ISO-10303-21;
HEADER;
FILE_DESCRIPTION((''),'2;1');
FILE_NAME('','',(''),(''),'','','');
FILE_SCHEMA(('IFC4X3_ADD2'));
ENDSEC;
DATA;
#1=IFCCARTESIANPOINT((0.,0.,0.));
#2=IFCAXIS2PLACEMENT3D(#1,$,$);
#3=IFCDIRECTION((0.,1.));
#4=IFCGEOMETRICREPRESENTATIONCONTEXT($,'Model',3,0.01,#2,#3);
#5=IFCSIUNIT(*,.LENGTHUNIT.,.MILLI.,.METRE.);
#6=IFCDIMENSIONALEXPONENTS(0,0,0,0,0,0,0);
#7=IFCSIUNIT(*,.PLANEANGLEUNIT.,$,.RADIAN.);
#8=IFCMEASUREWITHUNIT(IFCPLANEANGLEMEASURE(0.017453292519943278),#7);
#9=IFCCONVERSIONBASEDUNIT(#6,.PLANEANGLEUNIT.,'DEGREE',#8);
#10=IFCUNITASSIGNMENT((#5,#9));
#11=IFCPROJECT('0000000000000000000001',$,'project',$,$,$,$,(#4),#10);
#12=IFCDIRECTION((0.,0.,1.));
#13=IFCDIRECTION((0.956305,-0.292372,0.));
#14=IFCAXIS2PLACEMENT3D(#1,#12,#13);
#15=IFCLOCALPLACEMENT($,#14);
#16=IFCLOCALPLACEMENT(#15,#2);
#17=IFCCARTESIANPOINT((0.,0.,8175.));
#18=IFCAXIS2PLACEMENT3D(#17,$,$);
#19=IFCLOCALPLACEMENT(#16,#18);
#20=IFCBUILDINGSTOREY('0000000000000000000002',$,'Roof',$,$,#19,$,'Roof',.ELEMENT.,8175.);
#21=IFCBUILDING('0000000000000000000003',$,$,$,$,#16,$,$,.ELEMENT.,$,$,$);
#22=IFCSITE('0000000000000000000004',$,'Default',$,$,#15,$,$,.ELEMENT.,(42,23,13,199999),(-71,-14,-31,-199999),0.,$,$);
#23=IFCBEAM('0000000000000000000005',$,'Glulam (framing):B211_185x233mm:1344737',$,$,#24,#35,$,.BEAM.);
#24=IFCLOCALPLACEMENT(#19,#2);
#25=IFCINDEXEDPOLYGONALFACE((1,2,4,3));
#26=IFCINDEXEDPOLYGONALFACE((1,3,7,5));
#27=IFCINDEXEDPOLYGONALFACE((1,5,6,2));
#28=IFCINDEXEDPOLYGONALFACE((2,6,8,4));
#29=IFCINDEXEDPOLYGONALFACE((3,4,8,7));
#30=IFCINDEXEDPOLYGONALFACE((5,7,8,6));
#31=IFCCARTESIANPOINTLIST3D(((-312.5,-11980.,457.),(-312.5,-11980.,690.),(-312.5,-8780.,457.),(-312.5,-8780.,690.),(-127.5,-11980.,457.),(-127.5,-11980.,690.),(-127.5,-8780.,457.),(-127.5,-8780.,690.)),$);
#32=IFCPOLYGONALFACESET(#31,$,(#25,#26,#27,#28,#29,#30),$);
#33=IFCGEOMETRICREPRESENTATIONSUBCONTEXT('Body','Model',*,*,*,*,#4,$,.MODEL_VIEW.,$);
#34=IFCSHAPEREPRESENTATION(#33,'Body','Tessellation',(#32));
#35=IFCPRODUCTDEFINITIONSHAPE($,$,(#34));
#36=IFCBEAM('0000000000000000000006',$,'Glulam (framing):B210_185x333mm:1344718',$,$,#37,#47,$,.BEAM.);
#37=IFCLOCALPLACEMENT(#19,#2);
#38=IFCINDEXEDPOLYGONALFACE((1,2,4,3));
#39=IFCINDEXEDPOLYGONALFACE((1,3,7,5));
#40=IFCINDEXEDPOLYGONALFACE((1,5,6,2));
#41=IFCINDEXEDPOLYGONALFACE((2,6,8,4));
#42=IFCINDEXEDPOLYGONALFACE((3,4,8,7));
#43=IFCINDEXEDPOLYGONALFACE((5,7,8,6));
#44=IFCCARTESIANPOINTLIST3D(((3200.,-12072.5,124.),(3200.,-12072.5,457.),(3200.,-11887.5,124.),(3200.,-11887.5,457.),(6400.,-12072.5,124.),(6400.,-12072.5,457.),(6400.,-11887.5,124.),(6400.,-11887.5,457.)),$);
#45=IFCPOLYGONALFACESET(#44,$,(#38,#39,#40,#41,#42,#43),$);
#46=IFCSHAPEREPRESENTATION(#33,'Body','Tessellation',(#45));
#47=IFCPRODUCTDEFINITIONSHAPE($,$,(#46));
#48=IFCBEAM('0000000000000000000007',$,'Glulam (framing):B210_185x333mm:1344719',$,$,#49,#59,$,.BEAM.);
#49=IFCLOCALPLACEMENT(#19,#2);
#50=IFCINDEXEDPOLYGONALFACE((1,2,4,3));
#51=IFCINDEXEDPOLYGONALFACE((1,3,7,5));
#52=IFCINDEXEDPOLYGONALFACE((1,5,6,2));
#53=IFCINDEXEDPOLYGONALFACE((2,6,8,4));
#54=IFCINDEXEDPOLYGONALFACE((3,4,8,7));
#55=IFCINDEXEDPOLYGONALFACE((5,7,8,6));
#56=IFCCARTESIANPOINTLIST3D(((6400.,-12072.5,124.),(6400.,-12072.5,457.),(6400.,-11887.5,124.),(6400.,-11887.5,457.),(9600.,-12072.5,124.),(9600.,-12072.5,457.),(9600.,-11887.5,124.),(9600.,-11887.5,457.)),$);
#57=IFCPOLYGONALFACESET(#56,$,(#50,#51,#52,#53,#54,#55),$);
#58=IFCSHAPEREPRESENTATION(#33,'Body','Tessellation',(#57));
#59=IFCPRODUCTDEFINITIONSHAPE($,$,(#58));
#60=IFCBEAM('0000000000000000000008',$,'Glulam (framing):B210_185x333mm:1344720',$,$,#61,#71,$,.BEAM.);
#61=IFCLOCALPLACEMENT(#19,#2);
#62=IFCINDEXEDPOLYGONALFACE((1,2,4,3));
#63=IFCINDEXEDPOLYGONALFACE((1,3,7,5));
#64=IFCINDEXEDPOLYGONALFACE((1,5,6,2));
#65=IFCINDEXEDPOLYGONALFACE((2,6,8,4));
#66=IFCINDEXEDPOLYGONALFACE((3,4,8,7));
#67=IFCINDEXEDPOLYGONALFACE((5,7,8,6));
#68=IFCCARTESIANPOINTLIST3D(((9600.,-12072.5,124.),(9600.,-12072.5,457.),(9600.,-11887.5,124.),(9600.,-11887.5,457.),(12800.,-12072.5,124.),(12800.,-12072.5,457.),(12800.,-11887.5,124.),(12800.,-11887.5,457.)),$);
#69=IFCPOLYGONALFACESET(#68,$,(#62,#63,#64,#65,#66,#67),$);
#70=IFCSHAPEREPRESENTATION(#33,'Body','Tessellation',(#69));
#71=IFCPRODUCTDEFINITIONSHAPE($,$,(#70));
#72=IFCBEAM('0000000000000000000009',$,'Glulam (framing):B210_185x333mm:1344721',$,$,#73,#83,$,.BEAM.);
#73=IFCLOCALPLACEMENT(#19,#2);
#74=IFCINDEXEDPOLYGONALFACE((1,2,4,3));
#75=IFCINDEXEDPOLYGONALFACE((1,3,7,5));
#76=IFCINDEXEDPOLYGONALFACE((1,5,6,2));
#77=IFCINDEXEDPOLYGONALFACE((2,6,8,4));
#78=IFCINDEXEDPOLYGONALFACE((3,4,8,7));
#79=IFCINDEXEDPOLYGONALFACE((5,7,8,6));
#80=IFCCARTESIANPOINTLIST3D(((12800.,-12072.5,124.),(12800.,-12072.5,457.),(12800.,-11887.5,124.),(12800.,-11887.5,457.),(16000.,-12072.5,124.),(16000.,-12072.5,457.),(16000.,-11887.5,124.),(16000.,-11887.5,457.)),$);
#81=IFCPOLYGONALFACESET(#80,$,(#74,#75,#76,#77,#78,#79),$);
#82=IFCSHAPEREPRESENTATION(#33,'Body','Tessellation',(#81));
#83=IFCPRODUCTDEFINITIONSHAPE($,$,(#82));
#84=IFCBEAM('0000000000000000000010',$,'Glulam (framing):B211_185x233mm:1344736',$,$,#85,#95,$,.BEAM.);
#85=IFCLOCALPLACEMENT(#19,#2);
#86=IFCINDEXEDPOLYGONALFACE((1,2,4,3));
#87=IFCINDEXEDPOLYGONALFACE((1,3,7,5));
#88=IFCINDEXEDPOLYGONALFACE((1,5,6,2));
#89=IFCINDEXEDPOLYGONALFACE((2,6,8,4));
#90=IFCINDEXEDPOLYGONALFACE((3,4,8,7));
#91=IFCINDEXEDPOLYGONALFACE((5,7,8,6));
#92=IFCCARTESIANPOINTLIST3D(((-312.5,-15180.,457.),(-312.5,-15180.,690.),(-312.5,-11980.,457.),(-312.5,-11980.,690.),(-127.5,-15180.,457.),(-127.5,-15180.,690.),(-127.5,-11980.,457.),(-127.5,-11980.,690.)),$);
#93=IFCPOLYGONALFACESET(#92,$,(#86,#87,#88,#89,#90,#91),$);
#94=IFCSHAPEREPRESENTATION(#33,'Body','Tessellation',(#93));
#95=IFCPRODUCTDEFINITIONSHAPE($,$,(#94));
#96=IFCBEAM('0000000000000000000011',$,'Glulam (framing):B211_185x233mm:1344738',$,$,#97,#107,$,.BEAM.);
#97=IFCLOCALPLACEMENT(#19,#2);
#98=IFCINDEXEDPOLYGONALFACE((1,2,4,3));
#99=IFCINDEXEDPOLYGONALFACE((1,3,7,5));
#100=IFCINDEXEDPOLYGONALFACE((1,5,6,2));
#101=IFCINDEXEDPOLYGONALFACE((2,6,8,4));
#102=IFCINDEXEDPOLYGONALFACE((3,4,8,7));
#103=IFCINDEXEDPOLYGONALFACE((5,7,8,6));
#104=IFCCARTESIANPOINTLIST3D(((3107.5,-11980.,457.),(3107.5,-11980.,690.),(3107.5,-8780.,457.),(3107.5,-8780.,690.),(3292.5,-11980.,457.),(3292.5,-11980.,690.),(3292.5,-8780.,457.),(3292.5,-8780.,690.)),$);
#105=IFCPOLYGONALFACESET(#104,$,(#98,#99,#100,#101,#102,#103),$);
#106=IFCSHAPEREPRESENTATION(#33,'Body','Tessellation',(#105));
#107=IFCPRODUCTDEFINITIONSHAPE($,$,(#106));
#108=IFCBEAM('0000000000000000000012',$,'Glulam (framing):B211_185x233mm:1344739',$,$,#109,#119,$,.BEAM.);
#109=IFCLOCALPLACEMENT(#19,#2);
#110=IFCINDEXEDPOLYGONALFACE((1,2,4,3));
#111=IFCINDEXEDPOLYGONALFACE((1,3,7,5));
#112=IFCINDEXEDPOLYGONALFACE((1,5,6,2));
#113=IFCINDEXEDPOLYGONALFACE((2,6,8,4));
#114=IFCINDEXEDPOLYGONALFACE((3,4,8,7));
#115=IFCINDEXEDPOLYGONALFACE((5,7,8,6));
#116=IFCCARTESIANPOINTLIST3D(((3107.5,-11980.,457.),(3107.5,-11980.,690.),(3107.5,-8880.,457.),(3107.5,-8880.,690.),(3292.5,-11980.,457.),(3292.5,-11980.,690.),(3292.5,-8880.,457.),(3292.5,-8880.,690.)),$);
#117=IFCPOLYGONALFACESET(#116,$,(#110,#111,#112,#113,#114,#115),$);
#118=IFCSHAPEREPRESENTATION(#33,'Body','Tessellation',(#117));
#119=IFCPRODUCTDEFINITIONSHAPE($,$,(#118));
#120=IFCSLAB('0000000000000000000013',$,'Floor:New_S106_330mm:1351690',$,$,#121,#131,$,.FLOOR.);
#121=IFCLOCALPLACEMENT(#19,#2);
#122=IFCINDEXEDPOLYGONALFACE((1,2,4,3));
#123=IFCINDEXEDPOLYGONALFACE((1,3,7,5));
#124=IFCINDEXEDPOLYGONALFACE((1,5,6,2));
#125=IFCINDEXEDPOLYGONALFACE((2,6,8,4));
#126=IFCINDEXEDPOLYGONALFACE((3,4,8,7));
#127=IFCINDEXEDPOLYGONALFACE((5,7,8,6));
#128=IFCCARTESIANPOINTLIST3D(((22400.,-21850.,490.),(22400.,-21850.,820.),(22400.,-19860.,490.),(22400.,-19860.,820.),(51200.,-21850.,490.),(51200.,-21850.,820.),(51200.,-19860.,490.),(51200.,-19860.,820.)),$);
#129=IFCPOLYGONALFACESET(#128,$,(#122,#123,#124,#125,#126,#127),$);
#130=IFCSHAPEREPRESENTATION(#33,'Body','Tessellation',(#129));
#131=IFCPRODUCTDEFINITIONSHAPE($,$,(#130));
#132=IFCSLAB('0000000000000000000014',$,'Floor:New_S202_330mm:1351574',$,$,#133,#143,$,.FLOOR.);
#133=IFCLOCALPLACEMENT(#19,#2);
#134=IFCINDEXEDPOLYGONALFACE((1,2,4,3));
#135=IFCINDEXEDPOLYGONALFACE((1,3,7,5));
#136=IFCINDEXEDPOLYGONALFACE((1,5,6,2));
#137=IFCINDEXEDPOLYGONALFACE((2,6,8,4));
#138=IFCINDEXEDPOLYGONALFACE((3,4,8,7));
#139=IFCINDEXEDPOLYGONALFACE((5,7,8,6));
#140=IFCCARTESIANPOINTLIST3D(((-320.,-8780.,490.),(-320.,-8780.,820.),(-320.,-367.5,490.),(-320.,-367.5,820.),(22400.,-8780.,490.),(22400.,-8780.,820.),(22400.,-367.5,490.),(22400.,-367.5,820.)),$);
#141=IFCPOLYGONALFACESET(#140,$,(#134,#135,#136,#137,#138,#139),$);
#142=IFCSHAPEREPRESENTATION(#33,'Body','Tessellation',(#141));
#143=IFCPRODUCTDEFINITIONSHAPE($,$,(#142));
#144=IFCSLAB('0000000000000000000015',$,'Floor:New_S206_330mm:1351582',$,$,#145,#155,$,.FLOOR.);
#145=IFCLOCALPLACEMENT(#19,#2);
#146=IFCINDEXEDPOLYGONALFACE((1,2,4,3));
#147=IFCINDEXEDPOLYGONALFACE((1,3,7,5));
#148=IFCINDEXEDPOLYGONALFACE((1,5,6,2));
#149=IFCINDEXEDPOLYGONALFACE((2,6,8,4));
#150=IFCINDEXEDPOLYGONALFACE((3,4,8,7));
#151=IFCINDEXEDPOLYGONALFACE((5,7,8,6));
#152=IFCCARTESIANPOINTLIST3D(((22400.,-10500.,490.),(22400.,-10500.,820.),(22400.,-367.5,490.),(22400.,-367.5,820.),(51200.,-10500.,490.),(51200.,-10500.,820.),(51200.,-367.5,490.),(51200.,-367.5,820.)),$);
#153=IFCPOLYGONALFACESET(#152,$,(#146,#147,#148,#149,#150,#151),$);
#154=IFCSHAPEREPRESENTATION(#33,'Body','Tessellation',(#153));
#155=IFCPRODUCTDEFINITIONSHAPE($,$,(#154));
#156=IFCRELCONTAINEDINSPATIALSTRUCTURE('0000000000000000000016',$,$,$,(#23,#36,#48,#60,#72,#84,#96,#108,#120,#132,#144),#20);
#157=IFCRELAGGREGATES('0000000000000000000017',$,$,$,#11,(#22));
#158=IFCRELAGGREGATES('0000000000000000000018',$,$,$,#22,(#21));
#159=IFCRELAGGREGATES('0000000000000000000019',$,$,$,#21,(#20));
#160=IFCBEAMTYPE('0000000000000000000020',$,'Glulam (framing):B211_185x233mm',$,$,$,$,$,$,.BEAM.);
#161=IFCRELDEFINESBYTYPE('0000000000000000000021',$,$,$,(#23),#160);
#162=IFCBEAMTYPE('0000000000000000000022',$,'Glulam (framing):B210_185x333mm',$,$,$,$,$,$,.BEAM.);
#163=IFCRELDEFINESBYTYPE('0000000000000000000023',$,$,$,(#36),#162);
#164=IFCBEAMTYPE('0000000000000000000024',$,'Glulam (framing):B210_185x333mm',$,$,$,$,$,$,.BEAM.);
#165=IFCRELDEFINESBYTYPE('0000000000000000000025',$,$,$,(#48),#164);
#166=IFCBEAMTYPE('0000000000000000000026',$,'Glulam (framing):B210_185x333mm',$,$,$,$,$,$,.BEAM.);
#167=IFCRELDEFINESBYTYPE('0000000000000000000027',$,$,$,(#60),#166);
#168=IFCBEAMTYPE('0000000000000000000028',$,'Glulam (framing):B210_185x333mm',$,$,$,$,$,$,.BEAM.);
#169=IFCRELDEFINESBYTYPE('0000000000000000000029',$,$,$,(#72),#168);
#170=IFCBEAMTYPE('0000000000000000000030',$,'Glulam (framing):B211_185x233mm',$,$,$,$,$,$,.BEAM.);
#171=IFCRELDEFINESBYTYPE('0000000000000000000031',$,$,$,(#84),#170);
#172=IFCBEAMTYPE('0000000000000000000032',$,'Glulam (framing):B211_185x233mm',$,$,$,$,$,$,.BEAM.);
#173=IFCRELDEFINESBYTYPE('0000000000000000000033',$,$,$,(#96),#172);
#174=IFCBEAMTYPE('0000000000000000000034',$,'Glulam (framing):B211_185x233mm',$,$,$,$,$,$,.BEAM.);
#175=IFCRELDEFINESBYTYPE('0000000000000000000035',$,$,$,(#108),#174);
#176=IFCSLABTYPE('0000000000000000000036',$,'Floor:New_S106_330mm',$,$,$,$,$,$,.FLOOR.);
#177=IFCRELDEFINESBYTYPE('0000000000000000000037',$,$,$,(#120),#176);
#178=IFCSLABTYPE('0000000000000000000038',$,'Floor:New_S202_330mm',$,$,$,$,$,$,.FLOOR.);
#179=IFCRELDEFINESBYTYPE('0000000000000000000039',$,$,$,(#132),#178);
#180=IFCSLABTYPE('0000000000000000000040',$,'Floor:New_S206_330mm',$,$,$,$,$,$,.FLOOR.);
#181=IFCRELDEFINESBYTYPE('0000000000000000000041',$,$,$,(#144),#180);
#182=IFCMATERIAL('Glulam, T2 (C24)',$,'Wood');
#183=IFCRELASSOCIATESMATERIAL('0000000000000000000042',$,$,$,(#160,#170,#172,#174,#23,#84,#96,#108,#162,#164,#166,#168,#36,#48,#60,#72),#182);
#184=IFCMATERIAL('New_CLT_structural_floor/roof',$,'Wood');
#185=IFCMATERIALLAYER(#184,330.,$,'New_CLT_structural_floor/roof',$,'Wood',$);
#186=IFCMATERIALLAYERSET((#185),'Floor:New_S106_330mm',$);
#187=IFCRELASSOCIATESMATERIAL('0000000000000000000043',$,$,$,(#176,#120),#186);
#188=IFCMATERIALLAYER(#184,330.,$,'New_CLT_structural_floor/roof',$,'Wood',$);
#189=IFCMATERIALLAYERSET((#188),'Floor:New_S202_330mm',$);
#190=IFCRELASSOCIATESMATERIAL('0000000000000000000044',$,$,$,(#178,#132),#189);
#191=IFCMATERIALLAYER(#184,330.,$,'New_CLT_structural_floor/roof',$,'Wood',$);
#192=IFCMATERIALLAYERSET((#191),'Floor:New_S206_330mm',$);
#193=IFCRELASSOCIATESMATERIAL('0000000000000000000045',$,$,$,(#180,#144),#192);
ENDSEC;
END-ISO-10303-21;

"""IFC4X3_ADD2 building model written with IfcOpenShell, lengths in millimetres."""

from ifc_helpers import new_model, entity, si_unit, converted_unit, direction, frame, frame_2d, origin, origin_2d_with_axis, place, context, subcontext, project, spatial, rectangle, extrude, source, transform, mapped, material, layer, layer_set, layer_usage, material_profile, profile_set, profile_usage, type_object, type_shapes, element, save


model = new_model("IFC4X3_ADD2")

# Units and contexts
model_context = context("Model", 3, precision=0.01, world=origin(), true_north=direction((0.0, 1.0)))
body_context = subcontext(model_context, "Body", "Model", "MODEL_VIEW")
ifc_project = project(units=[si_unit("LENGTHUNIT", "METRE", prefix="MILLI"), converted_unit("PLANEANGLEUNIT", "DEGREE", entity("IfcPlaneAngleMeasure", 0.017453292519943278), si_unit("PLANEANGLEUNIT", "RADIAN"), dimensions=[0, 0, 0, 0, 0, 0, 0])], contexts=[model_context])

# Site, building, storey
site_placement = place(None, frame((0.0, 0.0, 0.0), z_axis=(0.0, 0.0, 1.0), x_axis=(0.956305, -0.292372, 0.0)))
site = spatial("IfcSite", under=ifc_project, at=site_placement, Name="Default", CompositionType="ELEMENT", RefLatitude=(42, 23, 13, 199999), RefLongitude=(-71, -14, -31, -199999), RefElevation=0.0)
building_placement = place(site_placement, origin())
building = spatial("IfcBuilding", under=site, at=building_placement, CompositionType="ELEMENT")
storey_placement = place(building_placement, frame((0.0, 0.0, 8175.0)))
storey = spatial("IfcBuildingStorey", under=building, at=storey_placement, Name="Roof", LongName="Roof", CompositionType="ELEMENT", Elevation=8175.0)

# Beams
ifc_material_1 = material(Name="Glulam, T2 (C24)", Category="Wood")
ifc_material_profile_1 = material_profile(ifc_material_1, rectangle(XDim=3200.0, YDim=185.0, at=origin_2d_with_axis()), Name="B211_185x233mm")
ifc_profile_set_1 = profile_set([ifc_material_profile_1], Name="B211_185x233mm")
ifc_profile_usage_1 = profile_usage(ifc_profile_set_1, cardinal=8)
beam_type_1 = type_object("IfcBeamType", Name="Glulam (framing):B211_185x233mm", PredefinedType="BEAM", material=ifc_profile_set_1)
shared_shape_1 = source(origin(), body_context, "Body", "SweptSolid", [
    extrude(rectangle(XDim=3200.0, YDim=185.0, at=origin_2d_with_axis()), frame((0.0, 0.0, -116.5), z_axis=(0.0, 0.0, 1.0), x_axis=(-1.0, 0.0, 0.0)), (0.0, 0.0, 1.0), 233.0),
])
type_shapes(beam_type_1, [shared_shape_1])
for number, where, z_axis, x_axis, name in (
    (1, (-220.0, -10380.0, 573.5), (0.0, 0.0, 1.0), (0.0, -1.0, 0.0), "Glulam (framing):B211_185x233mm:1344737"),
):
    element("IfcBeam", number, at=place(storey_placement, frame(where, z_axis=z_axis, x_axis=x_axis)), inside=storey, type_object=beam_type_1, material=ifc_profile_usage_1, Name=name, PredefinedType="BEAM", context=body_context, shape_type="MappedRepresentation", body=[
        mapped(shared_shape_1, transform((0.0, 0.0, 0.0), scale=1.0)),
    ])
ifc_material_profile_2 = material_profile(ifc_material_1, rectangle(XDim=185.0, YDim=3200.0, at=origin_2d_with_axis()), Name="B210_185x333mm")
ifc_profile_set_2 = profile_set([ifc_material_profile_2], Name="B210_185x333mm")
ifc_profile_usage_2 = profile_usage(ifc_profile_set_2, cardinal=8)
beam_type_2 = type_object("IfcBeamType", Name="Glulam (framing):B210_185x333mm", PredefinedType="BEAM", material=ifc_profile_set_2)
shared_shape_2 = source(origin(), body_context, "Body", "SweptSolid", [
    extrude(rectangle(XDim=185.0, YDim=3200.0, at=origin_2d_with_axis()), frame((0.0, 0.0, -166.5), z_axis=(0.0, 0.0, 1.0), x_axis=(0.0, 1.0, 0.0)), (0.0, 0.0, 1.0), 333.0),
])
type_shapes(beam_type_2, [shared_shape_2])
beam_1_placement = place(storey_placement, frame((4800.0, -11980.0, 290.5), z_axis=(0.0, 0.0, 1.0), x_axis=(-1.0, 0.0, 0.0)))
element("IfcBeam", 2, at=beam_1_placement, inside=storey, type_object=beam_type_2, material=ifc_profile_usage_2, Name="Glulam (framing):B210_185x333mm:1344718", PredefinedType="BEAM", context=body_context, shape_type="MappedRepresentation", body=[
    mapped(shared_shape_2, transform((0.0, 0.0, 0.0), scale=1.0)),
])
beam_type_3 = type_object("IfcBeamType", Name="Glulam (framing):B210_185x333mm", PredefinedType="BEAM", material=ifc_profile_set_2)
shared_shape_3 = source(origin(), body_context, "Body", "SweptSolid", [
    extrude(rectangle(XDim=185.0, YDim=3200.0, at=origin_2d_with_axis()), frame((0.0, 0.0, -166.5), z_axis=(0.0, 0.0, 1.0), x_axis=(0.0, 1.0, 0.0)), (0.0, 0.0, 1.0), 333.0),
])
type_shapes(beam_type_3, [shared_shape_3])
beam_2_placement = place(storey_placement, frame((8000.0, -11980.0, 290.5), z_axis=(0.0, 0.0, 1.0), x_axis=(-1.0, 0.0, 0.0)))
element("IfcBeam", 3, at=beam_2_placement, inside=storey, type_object=beam_type_3, material=ifc_profile_usage_2, Name="Glulam (framing):B210_185x333mm:1344719", PredefinedType="BEAM", context=body_context, shape_type="MappedRepresentation", body=[
    mapped(shared_shape_3, transform((0.0, 0.0, 0.0), scale=1.0)),
])
beam_type_4 = type_object("IfcBeamType", Name="Glulam (framing):B210_185x333mm", PredefinedType="BEAM", material=ifc_profile_set_2)
shared_shape_4 = source(origin(), body_context, "Body", "SweptSolid", [
    extrude(rectangle(XDim=185.0, YDim=3200.0, at=origin_2d_with_axis()), frame((0.0, 0.0, -166.5), z_axis=(0.0, 0.0, 1.0), x_axis=(0.0, 1.0, 0.0)), (0.0, 0.0, 1.0), 333.0),
])
type_shapes(beam_type_4, [shared_shape_4])
beam_3_placement = place(storey_placement, frame((11200.0, -11980.0, 290.5), z_axis=(0.0, 0.0, 1.0), x_axis=(-1.0, 0.0, 0.0)))
element("IfcBeam", 4, at=beam_3_placement, inside=storey, type_object=beam_type_4, material=ifc_profile_usage_2, Name="Glulam (framing):B210_185x333mm:1344720", PredefinedType="BEAM", context=body_context, shape_type="MappedRepresentation", body=[
    mapped(shared_shape_4, transform((0.0, 0.0, 0.0), scale=1.0)),
])
beam_type_5 = type_object("IfcBeamType", Name="Glulam (framing):B210_185x333mm", PredefinedType="BEAM", material=ifc_profile_set_2)
shared_shape_5 = source(origin(), body_context, "Body", "SweptSolid", [
    extrude(rectangle(XDim=185.0, YDim=3200.0, at=origin_2d_with_axis()), frame((0.0, 0.0, -166.5), z_axis=(0.0, 0.0, 1.0), x_axis=(0.0, 1.0, 0.0)), (0.0, 0.0, 1.0), 333.0),
])
type_shapes(beam_type_5, [shared_shape_5])
beam_4_placement = place(storey_placement, frame((14400.0, -11980.0, 290.5), z_axis=(0.0, 0.0, 1.0), x_axis=(-1.0, 0.0, 0.0)))
element("IfcBeam", 5, at=beam_4_placement, inside=storey, type_object=beam_type_5, material=ifc_profile_usage_2, Name="Glulam (framing):B210_185x333mm:1344721", PredefinedType="BEAM", context=body_context, shape_type="MappedRepresentation", body=[
    mapped(shared_shape_5, transform((0.0, 0.0, 0.0), scale=1.0)),
])
beam_type_6 = type_object("IfcBeamType", Name="Glulam (framing):B211_185x233mm", PredefinedType="BEAM", material=ifc_profile_set_1)
shared_shape_6 = source(origin(), body_context, "Body", "SweptSolid", [
    extrude(rectangle(XDim=3200.0, YDim=185.0, at=origin_2d_with_axis()), frame((0.0, 0.0, -116.5), z_axis=(0.0, 0.0, 1.0), x_axis=(-1.0, 0.0, 0.0)), (0.0, 0.0, 1.0), 233.0),
])
type_shapes(beam_type_6, [shared_shape_6])
beam_5_placement = place(storey_placement, frame((-220.0, -13580.0, 573.5), z_axis=(0.0, 0.0, 1.0), x_axis=(0.0, -1.0, 0.0)))
element("IfcBeam", 6, at=beam_5_placement, inside=storey, type_object=beam_type_6, material=ifc_profile_usage_1, Name="Glulam (framing):B211_185x233mm:1344736", PredefinedType="BEAM", context=body_context, shape_type="MappedRepresentation", body=[
    mapped(shared_shape_6, transform((0.0, 0.0, 0.0), scale=1.0)),
])
beam_type_7 = type_object("IfcBeamType", Name="Glulam (framing):B211_185x233mm", PredefinedType="BEAM", material=ifc_profile_set_1)
shared_shape_7 = source(origin(), body_context, "Body", "SweptSolid", [
    extrude(rectangle(XDim=3200.0, YDim=185.0, at=frame_2d((0.0, 0.0), x_axis=(1.0, 0.0))), frame((-3200.0, 0.0, -116.5), z_axis=(0.0, 0.0, 1.0), x_axis=(-1.0, 0.0, 0.0)), (0.0, 0.0, 1.0), 233.0),
])
type_shapes(beam_type_7, [shared_shape_7])
beam_6_placement = place(storey_placement, frame((3200.0, -13580.0, 573.5), z_axis=(0.0, 0.0, 1.0), x_axis=(0.0, -1.0, 0.0)))
element("IfcBeam", 7, at=beam_6_placement, inside=storey, type_object=beam_type_7, material=ifc_profile_usage_1, Name="Glulam (framing):B211_185x233mm:1344738", PredefinedType="BEAM", context=body_context, shape_type="MappedRepresentation", body=[
    mapped(shared_shape_7, transform((0.0, 0.0, 0.0), scale=1.0)),
])
beam_type_8 = type_object("IfcBeamType", Name="Glulam (framing):B211_185x233mm", PredefinedType="BEAM", material=ifc_profile_set_1)
shared_shape_8 = source(origin(), body_context, "Body", "SweptSolid", [
    extrude(rectangle(XDim=3100.0, YDim=185.0, at=origin_2d_with_axis()), frame((50.0, 0.0, -116.5), z_axis=(0.0, 0.0, 1.0), x_axis=(-1.0, 0.0, 0.0)), (0.0, 0.0, 1.0), 233.0),
])
type_shapes(beam_type_8, [shared_shape_8])
beam_7_placement = place(storey_placement, frame((3200.0, -10380.0, 573.5), z_axis=(0.0, 0.0, 1.0), x_axis=(0.0, -1.0, 0.0)))
element("IfcBeam", 8, at=beam_7_placement, inside=storey, type_object=beam_type_8, material=ifc_profile_usage_1, Name="Glulam (framing):B211_185x233mm:1344739", PredefinedType="BEAM", context=body_context, shape_type="MappedRepresentation", body=[
    mapped(shared_shape_8, transform((0.0, 0.0, 0.0), scale=1.0)),
])

# Slabs
ifc_material_2 = material(Name="New_CLT_structural_floor/roof", Category="Wood")
ifc_layer_1 = layer(ifc_material_2, 330.0, Name="New_CLT_structural_floor/roof", Category="Wood")
ifc_layer_set_1 = layer_set([ifc_layer_1], Name="Floor:New_S106_330mm")
ifc_layer_usage_1 = layer_usage(ifc_layer_set_1, "AXIS3", "POSITIVE", 0.0)
slab_type_1 = type_object("IfcSlabType", Name="Floor:New_S106_330mm", PredefinedType="FLOOR", material=ifc_layer_set_1)
slab_1_placement = place(storey_placement, origin())
element("IfcSlab", 9, at=slab_1_placement, inside=storey, type_object=slab_type_1, material=ifc_layer_usage_1, Name="Floor:New_S106_330mm:1351690", PredefinedType="FLOOR", context=body_context, shape_type="SweptSolid", body=[
    extrude(rectangle(XDim=1990.0, YDim=28800.0, at=frame_2d((0.0, 0.0), x_axis=(1.0, 0.0))), frame((36800.0, -20855.0, 820.0), z_axis=(0.0, 0.0, -1.0), x_axis=(0.0, 1.0, 0.0)), (0.0, 0.0, 1.0), 330.0),
])
ifc_layer_2 = layer(ifc_material_2, 330.0, Name="New_CLT_structural_floor/roof", Category="Wood")
ifc_layer_set_2 = layer_set([ifc_layer_2], Name="Floor:New_S202_330mm")
ifc_layer_usage_2 = layer_usage(ifc_layer_set_2, "AXIS3", "POSITIVE", 0.0)
slab_type_2 = type_object("IfcSlabType", Name="Floor:New_S202_330mm", PredefinedType="FLOOR", material=ifc_layer_set_2)
slab_2_placement = place(storey_placement, origin())
element("IfcSlab", 10, at=slab_2_placement, inside=storey, type_object=slab_type_2, material=ifc_layer_usage_2, Name="Floor:New_S202_330mm:1351574", PredefinedType="FLOOR", context=body_context, shape_type="SweptSolid", body=[
    extrude(rectangle(XDim=8412.5, YDim=22720.0, at=origin_2d_with_axis()), frame((11040.0, -4573.8, 820.0), z_axis=(0.0, 0.0, -1.0), x_axis=(0.0, 1.0, 0.0)), (0.0, 0.0, 1.0), 330.0),
])
ifc_layer_3 = layer(ifc_material_2, 330.0, Name="New_CLT_structural_floor/roof", Category="Wood")
ifc_layer_set_3 = layer_set([ifc_layer_3], Name="Floor:New_S206_330mm")
ifc_layer_usage_3 = layer_usage(ifc_layer_set_3, "AXIS3", "POSITIVE", 0.0)
slab_type_3 = type_object("IfcSlabType", Name="Floor:New_S206_330mm", PredefinedType="FLOOR", material=ifc_layer_set_3)
slab_3_placement = place(storey_placement, origin())
element("IfcSlab", 11, at=slab_3_placement, inside=storey, type_object=slab_type_3, material=ifc_layer_usage_3, Name="Floor:New_S206_330mm:1351582", PredefinedType="FLOOR", context=body_context, shape_type="SweptSolid", body=[
    extrude(rectangle(XDim=10132.5, YDim=28800.0, at=frame_2d((0.0, 0.0), x_axis=(1.0, 0.0))), frame((36800.0, -5433.8, 820.0), z_axis=(0.0, 0.0, -1.0), x_axis=(0.0, 1.0, 0.0)), (0.0, 0.0, 1.0), 330.0),
])

save(model, "model.ifc")
